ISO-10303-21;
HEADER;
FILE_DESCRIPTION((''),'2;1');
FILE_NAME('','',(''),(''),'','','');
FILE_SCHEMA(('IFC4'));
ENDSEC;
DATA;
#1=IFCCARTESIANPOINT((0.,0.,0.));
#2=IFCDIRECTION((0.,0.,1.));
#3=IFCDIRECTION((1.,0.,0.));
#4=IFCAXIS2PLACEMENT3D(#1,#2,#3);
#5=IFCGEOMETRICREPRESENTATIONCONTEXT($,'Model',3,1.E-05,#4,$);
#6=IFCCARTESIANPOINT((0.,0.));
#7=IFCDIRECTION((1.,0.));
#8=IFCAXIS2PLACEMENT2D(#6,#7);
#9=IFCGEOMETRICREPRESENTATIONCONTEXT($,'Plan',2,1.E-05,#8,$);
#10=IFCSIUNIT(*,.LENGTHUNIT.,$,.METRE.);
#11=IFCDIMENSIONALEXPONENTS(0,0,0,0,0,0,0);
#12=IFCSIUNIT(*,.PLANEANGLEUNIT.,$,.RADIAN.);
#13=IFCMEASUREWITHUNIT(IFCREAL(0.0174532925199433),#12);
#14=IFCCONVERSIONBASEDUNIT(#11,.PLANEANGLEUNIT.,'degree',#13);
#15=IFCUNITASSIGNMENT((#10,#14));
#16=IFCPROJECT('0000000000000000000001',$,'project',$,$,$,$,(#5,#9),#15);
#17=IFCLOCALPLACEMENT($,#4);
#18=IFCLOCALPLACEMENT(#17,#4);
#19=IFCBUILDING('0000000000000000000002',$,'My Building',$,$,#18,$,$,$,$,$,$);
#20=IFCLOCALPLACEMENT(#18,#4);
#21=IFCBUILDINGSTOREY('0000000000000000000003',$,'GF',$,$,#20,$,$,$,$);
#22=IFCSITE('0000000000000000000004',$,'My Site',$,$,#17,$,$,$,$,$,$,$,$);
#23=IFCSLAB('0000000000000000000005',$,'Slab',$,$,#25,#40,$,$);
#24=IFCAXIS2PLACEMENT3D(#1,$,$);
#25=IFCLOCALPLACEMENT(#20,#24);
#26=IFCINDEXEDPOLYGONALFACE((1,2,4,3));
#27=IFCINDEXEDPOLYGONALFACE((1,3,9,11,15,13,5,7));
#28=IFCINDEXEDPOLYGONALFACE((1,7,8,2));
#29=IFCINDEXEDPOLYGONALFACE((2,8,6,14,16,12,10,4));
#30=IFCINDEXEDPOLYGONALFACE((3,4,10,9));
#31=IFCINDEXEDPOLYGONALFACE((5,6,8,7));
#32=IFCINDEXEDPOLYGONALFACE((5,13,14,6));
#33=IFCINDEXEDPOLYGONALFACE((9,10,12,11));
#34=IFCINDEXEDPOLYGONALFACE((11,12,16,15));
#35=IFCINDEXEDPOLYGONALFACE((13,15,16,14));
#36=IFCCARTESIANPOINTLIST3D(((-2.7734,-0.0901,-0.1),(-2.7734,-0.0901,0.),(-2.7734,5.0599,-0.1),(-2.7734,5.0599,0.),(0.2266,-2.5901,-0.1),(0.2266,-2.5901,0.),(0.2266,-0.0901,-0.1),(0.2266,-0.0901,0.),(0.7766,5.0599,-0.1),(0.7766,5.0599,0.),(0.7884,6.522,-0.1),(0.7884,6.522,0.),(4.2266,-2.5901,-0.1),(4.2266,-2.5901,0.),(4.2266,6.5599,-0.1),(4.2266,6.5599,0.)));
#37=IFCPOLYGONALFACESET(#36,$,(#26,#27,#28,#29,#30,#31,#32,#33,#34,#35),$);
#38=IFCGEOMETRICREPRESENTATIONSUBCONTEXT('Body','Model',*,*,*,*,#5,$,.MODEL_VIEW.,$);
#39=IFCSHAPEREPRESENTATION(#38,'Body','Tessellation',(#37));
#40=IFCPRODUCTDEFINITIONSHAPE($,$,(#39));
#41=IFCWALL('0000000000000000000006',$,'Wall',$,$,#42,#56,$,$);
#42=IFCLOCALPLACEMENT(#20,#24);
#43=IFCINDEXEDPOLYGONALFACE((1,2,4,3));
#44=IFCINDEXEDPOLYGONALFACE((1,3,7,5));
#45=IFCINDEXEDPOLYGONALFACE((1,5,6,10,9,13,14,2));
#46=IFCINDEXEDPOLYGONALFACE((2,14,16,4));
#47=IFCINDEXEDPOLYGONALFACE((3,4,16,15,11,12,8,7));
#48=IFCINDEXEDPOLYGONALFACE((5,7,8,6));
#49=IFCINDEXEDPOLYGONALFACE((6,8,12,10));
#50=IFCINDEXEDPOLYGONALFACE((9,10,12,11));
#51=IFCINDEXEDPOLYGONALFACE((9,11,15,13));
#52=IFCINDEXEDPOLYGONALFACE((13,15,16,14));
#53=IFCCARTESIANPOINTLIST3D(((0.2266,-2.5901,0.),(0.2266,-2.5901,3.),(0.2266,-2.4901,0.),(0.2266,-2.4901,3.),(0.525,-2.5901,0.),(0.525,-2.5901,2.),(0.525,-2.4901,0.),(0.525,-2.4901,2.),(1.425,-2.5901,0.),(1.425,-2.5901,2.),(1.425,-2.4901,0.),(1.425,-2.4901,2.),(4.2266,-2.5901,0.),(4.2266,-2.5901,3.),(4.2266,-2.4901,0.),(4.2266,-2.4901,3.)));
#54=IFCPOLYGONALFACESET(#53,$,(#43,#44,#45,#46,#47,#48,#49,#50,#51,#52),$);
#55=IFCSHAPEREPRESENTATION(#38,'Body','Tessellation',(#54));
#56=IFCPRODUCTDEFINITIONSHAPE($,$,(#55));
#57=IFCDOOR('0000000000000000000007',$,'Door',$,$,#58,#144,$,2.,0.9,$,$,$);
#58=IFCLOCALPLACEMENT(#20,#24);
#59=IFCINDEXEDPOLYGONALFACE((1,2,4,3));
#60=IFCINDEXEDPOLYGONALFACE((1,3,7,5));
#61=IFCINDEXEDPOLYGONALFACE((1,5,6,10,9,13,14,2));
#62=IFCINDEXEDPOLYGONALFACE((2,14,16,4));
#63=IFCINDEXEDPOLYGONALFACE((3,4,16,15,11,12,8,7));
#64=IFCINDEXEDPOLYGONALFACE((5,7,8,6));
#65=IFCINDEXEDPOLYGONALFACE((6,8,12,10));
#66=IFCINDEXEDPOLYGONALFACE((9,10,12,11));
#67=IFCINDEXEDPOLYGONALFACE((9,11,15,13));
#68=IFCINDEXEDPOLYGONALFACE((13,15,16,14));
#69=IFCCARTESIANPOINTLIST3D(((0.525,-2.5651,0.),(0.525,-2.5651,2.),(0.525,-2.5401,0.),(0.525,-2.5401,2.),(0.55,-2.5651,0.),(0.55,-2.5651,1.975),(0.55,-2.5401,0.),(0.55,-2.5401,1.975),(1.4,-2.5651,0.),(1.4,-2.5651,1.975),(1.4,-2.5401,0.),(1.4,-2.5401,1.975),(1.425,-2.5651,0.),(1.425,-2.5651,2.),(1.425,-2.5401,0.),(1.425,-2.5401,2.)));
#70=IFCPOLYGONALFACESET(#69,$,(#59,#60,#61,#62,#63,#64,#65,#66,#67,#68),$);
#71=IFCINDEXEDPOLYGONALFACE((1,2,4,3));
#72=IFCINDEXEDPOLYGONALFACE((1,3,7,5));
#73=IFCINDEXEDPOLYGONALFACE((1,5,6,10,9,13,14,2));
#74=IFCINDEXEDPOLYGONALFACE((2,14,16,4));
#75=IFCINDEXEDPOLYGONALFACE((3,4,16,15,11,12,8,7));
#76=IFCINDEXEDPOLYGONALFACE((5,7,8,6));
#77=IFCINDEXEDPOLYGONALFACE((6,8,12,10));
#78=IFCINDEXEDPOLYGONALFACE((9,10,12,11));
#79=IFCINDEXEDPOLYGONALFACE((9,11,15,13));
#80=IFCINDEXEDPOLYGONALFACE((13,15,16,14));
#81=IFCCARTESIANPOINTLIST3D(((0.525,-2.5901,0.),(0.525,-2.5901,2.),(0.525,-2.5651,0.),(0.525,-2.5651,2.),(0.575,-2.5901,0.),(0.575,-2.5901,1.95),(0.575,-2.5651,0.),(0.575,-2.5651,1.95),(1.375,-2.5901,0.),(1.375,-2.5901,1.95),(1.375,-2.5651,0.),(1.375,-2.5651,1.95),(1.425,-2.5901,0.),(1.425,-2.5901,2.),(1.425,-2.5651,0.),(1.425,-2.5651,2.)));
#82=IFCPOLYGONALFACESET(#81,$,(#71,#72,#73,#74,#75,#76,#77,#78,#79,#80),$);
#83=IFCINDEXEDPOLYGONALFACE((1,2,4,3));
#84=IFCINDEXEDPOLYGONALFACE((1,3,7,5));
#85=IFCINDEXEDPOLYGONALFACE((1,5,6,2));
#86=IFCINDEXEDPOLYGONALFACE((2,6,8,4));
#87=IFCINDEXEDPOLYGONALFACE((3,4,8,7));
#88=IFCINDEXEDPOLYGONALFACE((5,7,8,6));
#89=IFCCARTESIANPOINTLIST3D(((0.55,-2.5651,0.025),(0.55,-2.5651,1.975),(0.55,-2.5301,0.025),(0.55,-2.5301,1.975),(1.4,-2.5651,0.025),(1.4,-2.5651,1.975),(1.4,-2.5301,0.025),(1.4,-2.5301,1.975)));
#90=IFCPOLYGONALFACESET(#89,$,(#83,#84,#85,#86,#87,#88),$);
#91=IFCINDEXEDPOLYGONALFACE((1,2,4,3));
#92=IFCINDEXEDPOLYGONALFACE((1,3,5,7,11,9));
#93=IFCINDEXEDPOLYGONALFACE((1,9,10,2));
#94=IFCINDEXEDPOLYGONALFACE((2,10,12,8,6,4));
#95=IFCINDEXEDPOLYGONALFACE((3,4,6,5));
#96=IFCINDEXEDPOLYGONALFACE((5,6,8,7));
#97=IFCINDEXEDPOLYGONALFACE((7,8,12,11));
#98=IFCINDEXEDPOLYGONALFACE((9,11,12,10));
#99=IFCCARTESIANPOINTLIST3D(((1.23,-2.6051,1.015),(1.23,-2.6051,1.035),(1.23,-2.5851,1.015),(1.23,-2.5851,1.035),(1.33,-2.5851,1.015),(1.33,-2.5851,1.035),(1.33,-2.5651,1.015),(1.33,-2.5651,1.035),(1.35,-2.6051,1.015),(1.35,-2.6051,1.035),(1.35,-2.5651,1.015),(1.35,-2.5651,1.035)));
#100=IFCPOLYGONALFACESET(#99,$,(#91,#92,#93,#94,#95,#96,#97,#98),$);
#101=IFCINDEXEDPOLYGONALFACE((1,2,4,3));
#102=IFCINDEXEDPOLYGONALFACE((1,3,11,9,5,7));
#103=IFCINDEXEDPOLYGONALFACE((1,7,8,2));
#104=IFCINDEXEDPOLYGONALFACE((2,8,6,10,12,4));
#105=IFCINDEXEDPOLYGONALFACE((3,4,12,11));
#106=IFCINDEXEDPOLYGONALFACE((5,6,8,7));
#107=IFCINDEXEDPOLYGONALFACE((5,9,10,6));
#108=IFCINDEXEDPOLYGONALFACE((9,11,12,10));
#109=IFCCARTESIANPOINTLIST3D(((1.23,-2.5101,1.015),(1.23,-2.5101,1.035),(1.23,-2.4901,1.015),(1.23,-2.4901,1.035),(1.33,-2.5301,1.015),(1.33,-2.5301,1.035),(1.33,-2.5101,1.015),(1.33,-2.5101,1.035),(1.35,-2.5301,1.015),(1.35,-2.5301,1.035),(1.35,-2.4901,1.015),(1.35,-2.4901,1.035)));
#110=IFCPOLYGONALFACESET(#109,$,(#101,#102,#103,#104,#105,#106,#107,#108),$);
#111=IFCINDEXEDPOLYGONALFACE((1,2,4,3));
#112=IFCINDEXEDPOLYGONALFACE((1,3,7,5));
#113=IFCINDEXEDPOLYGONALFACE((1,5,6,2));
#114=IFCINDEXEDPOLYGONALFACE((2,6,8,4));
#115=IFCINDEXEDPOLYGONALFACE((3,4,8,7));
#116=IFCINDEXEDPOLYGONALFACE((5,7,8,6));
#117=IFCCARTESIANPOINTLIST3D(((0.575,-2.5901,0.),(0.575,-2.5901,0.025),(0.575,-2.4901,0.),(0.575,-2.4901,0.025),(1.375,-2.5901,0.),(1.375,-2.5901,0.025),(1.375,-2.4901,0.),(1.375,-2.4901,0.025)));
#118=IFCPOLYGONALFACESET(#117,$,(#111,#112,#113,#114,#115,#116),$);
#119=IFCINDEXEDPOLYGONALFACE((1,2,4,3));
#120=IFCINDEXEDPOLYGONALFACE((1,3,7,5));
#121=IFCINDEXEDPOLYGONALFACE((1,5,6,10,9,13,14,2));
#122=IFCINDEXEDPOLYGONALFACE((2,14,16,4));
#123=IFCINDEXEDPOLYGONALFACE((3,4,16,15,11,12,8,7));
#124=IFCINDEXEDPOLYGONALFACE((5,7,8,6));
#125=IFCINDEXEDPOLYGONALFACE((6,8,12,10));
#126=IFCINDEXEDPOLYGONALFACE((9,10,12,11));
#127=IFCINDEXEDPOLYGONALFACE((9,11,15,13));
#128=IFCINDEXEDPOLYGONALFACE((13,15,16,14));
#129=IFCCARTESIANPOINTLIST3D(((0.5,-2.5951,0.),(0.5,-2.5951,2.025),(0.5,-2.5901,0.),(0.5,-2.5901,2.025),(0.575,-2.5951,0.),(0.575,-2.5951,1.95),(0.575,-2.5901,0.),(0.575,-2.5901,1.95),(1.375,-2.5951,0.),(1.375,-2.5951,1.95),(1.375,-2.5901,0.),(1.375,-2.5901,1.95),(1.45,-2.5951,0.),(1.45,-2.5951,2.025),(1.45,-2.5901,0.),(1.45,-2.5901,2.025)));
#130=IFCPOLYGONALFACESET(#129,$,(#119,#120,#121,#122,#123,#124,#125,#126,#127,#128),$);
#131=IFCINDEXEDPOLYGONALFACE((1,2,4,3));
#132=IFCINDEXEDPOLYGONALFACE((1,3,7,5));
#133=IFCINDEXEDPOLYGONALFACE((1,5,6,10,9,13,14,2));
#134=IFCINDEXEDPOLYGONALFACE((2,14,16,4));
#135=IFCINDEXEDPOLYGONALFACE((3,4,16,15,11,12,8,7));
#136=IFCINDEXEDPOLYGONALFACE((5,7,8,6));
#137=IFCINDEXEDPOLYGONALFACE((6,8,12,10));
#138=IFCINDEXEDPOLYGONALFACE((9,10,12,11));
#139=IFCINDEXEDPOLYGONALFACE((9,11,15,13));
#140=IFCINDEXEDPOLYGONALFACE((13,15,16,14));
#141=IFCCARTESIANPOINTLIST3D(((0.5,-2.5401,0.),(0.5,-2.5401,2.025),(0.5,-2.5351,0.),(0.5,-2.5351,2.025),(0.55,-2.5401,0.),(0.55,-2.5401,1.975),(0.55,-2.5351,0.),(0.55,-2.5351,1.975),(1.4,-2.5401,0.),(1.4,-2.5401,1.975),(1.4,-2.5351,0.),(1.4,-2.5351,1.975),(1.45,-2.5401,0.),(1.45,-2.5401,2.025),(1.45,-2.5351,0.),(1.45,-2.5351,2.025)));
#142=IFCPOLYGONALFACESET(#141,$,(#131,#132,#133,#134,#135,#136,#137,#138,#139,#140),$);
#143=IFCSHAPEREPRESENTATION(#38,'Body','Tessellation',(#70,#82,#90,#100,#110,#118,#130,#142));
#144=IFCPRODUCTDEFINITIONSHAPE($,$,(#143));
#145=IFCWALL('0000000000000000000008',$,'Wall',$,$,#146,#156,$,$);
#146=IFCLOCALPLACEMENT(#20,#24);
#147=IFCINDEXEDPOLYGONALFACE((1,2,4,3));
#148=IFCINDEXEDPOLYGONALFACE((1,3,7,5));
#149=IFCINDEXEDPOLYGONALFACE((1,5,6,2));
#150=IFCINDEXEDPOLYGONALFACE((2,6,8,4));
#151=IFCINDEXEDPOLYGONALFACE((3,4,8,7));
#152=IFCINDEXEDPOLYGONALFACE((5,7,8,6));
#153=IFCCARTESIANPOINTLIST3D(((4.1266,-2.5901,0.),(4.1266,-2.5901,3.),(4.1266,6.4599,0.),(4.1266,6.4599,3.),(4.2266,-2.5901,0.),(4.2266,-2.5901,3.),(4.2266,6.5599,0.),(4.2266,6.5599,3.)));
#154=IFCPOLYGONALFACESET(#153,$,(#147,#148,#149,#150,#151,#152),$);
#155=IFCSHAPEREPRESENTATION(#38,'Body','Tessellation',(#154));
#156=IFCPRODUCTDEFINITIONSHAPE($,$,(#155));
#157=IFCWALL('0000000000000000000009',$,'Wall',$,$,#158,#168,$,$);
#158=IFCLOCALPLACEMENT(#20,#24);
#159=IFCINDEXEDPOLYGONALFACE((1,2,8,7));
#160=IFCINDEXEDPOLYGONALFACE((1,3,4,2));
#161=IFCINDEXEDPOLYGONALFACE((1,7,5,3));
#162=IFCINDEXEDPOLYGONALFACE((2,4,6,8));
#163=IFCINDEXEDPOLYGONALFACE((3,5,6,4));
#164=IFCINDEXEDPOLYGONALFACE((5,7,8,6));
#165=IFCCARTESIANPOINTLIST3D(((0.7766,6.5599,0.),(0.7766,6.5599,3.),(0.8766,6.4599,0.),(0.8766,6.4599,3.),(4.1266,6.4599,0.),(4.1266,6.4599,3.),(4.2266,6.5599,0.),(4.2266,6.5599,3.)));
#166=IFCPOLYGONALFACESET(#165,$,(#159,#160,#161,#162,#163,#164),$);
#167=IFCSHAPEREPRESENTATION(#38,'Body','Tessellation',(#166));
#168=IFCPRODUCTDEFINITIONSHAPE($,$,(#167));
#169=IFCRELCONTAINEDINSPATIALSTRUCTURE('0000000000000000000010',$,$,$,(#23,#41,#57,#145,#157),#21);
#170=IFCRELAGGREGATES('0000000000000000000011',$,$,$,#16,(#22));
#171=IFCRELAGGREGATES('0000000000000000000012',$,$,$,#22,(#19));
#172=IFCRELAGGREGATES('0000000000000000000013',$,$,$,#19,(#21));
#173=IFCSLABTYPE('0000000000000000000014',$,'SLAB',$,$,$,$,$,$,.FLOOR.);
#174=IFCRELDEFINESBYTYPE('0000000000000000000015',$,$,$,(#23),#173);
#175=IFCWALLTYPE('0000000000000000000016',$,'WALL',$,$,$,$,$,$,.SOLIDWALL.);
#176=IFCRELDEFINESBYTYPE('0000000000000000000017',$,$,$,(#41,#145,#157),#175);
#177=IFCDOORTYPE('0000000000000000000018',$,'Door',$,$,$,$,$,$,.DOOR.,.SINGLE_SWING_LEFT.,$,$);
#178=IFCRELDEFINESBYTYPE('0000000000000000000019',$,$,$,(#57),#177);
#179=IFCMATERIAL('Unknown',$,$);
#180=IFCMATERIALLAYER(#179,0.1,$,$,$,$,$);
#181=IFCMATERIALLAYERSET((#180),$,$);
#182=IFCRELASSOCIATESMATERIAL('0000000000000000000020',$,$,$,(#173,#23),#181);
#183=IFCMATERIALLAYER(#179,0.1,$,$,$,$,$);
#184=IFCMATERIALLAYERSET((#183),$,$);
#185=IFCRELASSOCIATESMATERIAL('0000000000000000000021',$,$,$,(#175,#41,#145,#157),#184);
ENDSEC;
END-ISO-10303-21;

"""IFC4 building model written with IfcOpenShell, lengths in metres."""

from ifc_helpers import new_model, entity, si_unit, converted_unit, frame, origin_with_axes, origin_2d_with_axis, place, context, subcontext, project, spatial, line, indexed_curve, outline, extrude, shape, source, transform, mapped, material, layer, layer_set, layer_usage, type_object, type_shapes, element, fill, save


model = new_model("IFC4")

# Units and contexts
model_context = context("Model", 3, precision=1e-05, world=origin_with_axes())
plan_context = context("Plan", 2, precision=1e-05, world=origin_2d_with_axis())
body_context_1 = subcontext(model_context, "Body", "Model", "MODEL_VIEW")
body_context_2 = subcontext(plan_context, "Body", "Plan", "PLAN_VIEW")
ifc_project = project(units=[si_unit("LENGTHUNIT", "METRE"), converted_unit("PLANEANGLEUNIT", "degree", entity("IfcReal", 0.0174532925199433), si_unit("PLANEANGLEUNIT", "RADIAN"), dimensions=[0, 0, 0, 0, 0, 0, 0])], contexts=[model_context, plan_context])

# Site, building, storey
site_placement = place(None, origin_with_axes())
site = spatial("IfcSite", under=ifc_project, at=site_placement, Name="My Site")
building_placement = place(site_placement, origin_with_axes())
building = spatial("IfcBuilding", under=site, at=building_placement, Name="My Building")
storey_placement = place(building_placement, origin_with_axes())
storey = spatial("IfcBuildingStorey", under=building, at=storey_placement, Name="GF")

# Slab
ifc_material = material(Name="Unknown")
ifc_layer_1 = layer(ifc_material, 0.1)
ifc_layer_set_1 = layer_set([ifc_layer_1])
ifc_layer_usage_1 = layer_usage(ifc_layer_set_1, "AXIS3", "POSITIVE", -0.1)
slab_type = type_object("IfcSlabType", Name="SLAB", PredefinedType="FLOOR", material=ifc_layer_set_1)
slab_placement = place(storey_placement, frame((4.2266, -2.5901, 0.0), z_axis=(0.0, 0.0, 1.0), x_axis=(1.0, 0.0, 0.0)))
element("IfcSlab", 1, at=slab_placement, inside=storey, type_object=slab_type, material=ifc_layer_usage_1, Name="Slab", context=body_context_1, shape_type="SweptSolid", body=[
    extrude(outline(indexed_curve([(0.0, 0.0), (0.0, 9.15), (-3.4382, 9.1121), (-3.45, 7.65), (-7.0, 7.65), (-7.0, 2.5), (-4.0, 2.5), (-4.0, 0.0), (0.0, 0.0)])), frame((0.0, 0.0, -0.1), z_axis=(0.0, 0.0, 1.0), x_axis=(1.0, 0.0, 0.0)), (0.0, 0.0, 1.0), 0.1),
])

# Wall, opening, door
ifc_layer_2 = layer(ifc_material, 0.1)
ifc_layer_set_2 = layer_set([ifc_layer_2])
ifc_layer_usage_2 = layer_usage(ifc_layer_set_2, "AXIS2", "POSITIVE", 0.0)
wall_type = type_object("IfcWallType", Name="WALL", PredefinedType="SOLIDWALL", material=ifc_layer_set_2)
wall_1_placement = place(storey_placement, frame((0.2266, -2.5901, 0.0), z_axis=(0.0, 0.0, 1.0), x_axis=(1.0, 0.0, 0.0)))
wall_1 = element("IfcWall", 2, at=wall_1_placement, inside=storey, type_object=wall_type, material=ifc_layer_usage_2, Name="Wall", context=body_context_1, shape_type="SweptSolid", body=[
    extrude(outline(indexed_curve([(0.0, 0.0), (0.0, 0.1), (4.0, 0.1), (4.0, 0.0)], segments=[line(1, 2, 3, 4, 1)])), origin_with_axes(), (0.0, 0.0, 1.0), 3.0),
])
shared_shape_1 = source(origin_with_axes(), body_context_1, "Body", "SweptSolid", [
    extrude(outline(indexed_curve([(0.0, 0.0), (0.9, 0.0), (0.9, 2.0), (0.0, 2.0)], segments=[line(1, 2, 3, 4, 1)])), frame((0.0, -0.6, 0.0), z_axis=(0.0, -1.0, 0.0), x_axis=(1.0, 0.0, 0.0)), (0.0, 0.0, -1.0), 1.2),
])
opening_1_placement = place(wall_1_placement, frame((0.2984, 0.0, 0.0), z_axis=(0.0, 0.0, 1.0), x_axis=(1.0, 0.0, 0.0)))
opening_1 = element("IfcOpeningElement", 3, at=opening_1_placement, cuts=wall_1, PredefinedType="OPENING", context=body_context_1, shape_type="MappedRepresentation", body=[
    mapped(shared_shape_1, transform((0.0, 0.0, 0.0), x_axis=(1.0, 0.0, 0.0), y_axis=(0.0, 1.0, 0.0), z_axis=(0.0, 0.0, 1.0), scale=1.0)),
])
door_type = type_object("IfcDoorType", Name="Door", OperationType="SINGLE_SWING_LEFT", PredefinedType="DOOR")
shared_shape_2 = source(origin_with_axes(), body_context_1, "Body", "SweptSolid", [
    extrude(outline(indexed_curve([(0.0, 0.0), (0.0, 2.0), (0.9, 2.0), (0.9, 0.0), (0.875, 0.0), (0.875, 1.975), (0.025, 1.975), (0.025, 0.0)], segments=[line(1, 2, 3, 4, 5, 6, 7, 8, 1)])), frame((0.0, 0.025, 0.0), z_axis=(0.0, -1.0, 0.0), x_axis=(1.0, 0.0, 0.0)), (0.0, 0.0, -1.0), 0.025),
    extrude(outline(indexed_curve([(0.0, 0.0), (0.0, 2.0), (0.9, 2.0), (0.9, 0.0), (0.85, 0.0), (0.85, 1.95), (0.05, 1.95), (0.05, 0.0)], segments=[line(1, 2, 3, 4, 5, 6, 7, 8, 1)])), frame((0.0, 0.0, 0.0), z_axis=(0.0, -1.0, 0.0), x_axis=(1.0, 0.0, 0.0)), (0.0, 0.0, -1.0), 0.025),
    extrude(outline(indexed_curve([(0.0, 0.0), (0.85, 0.0), (0.85, 0.035), (0.0, 0.035)], segments=[line(1, 2, 3, 4, 1)])), frame((0.025, 0.025, 0.025), z_axis=(0.0, 0.0, 1.0), x_axis=(1.0, 0.0, 0.0)), (0.0, 0.0, 1.0), 1.95),
    extrude(outline(indexed_curve([(0.0, 0.0), (0.0, -0.04), (-0.12, -0.04), (-0.12, -0.02), (-0.02, -0.02), (-0.02, 0.0)], segments=[line(1, 2, 3, 4, 5, 6, 1)])), frame((0.825, 0.025, 1.015), z_axis=(0.0, 0.0, 1.0), x_axis=(1.0, 0.0, 0.0)), (0.0, 0.0, 1.0), 0.02),
    extrude(outline(indexed_curve([(0.0, 0.0), (0.0, 0.04), (-0.12, 0.04), (-0.12, 0.02), (-0.02, 0.02), (-0.02, 0.0)], segments=[line(1, 2, 3, 4, 5, 6, 1)])), frame((0.825, 0.06, 1.015), z_axis=(0.0, 0.0, 1.0), x_axis=(1.0, 0.0, 0.0)), (0.0, 0.0, 1.0), 0.02),
    extrude(outline(indexed_curve([(0.0, 0.0), (0.8, 0.0), (0.8, 0.1), (0.0, 0.1)], segments=[line(1, 2, 3, 4, 1)])), frame((0.05, 0.0, 0.0), z_axis=(0.0, 0.0, 1.0), x_axis=(1.0, 0.0, 0.0)), (0.0, 0.0, 1.0), 0.025),
    extrude(outline(indexed_curve([(0.0, 0.0), (0.0, 2.025), (0.95, 2.025), (0.95, 0.0), (0.875, 0.0), (0.875, 1.95), (0.075, 1.95), (0.075, 0.0)], segments=[line(1, 2, 3, 4, 5, 6, 7, 8, 1)])), frame((-0.025, -0.005, 0.0), z_axis=(0.0, -1.0, 0.0), x_axis=(1.0, 0.0, 0.0)), (0.0, 0.0, -1.0), 0.005),
    extrude(outline(indexed_curve([(0.0, 0.0), (0.0, 2.025), (0.95, 2.025), (0.95, 0.0), (0.9, 0.0), (0.9, 1.975), (0.05, 1.975), (0.05, 0.0)], segments=[line(1, 2, 3, 4, 5, 6, 7, 8, 1)])), frame((-0.025, 0.05, 0.0), z_axis=(0.0, -1.0, 0.0), x_axis=(1.0, 0.0, 0.0)), (0.0, 0.0, -1.0), 0.005),
])
shared_shape_3 = source(origin_with_axes(), body_context_2, "Body", "Curve2D", [
    entity("IfcIndexedPolyCurve", entity("IfcCartesianPointList2D", [[0.0, 0.0], [0.0, 0.05], [0.025, 0.05], [0.025, 0.025], [0.05, 0.025], [0.05, 0.0]]), [entity("IfcLineIndex", [1, 2, 3, 4, 5, 6, 1])]),
    entity("IfcIndexedPolyCurve", entity("IfcCartesianPointList2D", [[0.9, 0.0], [0.9, 0.05], [0.875, 0.05], [0.875, 0.025], [0.85, 0.025], [0.85, 0.0]]), [entity("IfcLineIndex", [1, 2, 3, 4, 5, 6, 1])]),
    entity("IfcTrimmedCurve", entity("IfcEllipse", entity("IfcAxis2Placement2D", entity("IfcCartesianPoint", [0.06, 0.05]), entity("IfcDirection", [1.0, 0.0])), 0.815, 0.85), [entity("IfcCartesianPoint", [0.875, 0.05])], [entity("IfcCartesianPoint", [0.06, 0.9])], True, "CARTESIAN"),
    entity("IfcIndexedPolyCurve", entity("IfcCartesianPointList2D", [[0.025, 0.05], [0.06, 0.05], [0.06, 0.9], [0.025, 0.9]]), [entity("IfcLineIndex", [1, 2, 3, 4, 1])]),
])
type_shapes(door_type, [shared_shape_2, shared_shape_3])
door_1_placement = place(opening_1_placement, origin_with_axes())
door_1 = element("IfcDoor", 4, at=door_1_placement, inside=storey, type_object=door_type, Name="Door", OverallHeight=2.0, OverallWidth=0.9, shapes=[
    shape(body_context_1, "Body", "MappedRepresentation", [mapped(shared_shape_2, transform((0.0, 0.0, 0.0), x_axis=(1.0, 0.0, 0.0), y_axis=(0.0, 1.0, 0.0), z_axis=(0.0, 0.0, 1.0), scale=1.0))]),
    shape(body_context_2, "Body", "MappedRepresentation", [mapped(shared_shape_3, transform((0.0, 0.0, 0.0), x_axis=(1.0, 0.0, 0.0), y_axis=(0.0, 1.0, 0.0), z_axis=(0.0, 0.0, 1.0), scale=1.0))]),
])
fill(opening_1, door_1)

# Walls
ifc_layer_usage_3 = layer_usage(ifc_layer_set_2, "AXIS2", "POSITIVE", 0.0)
wall_2_placement = place(storey_placement, frame((4.2266, -2.5901, 0.0), z_axis=(0.0, 0.0, 1.0), x_axis=(0.0, 1.0, 0.0)))
element("IfcWall", 5, at=wall_2_placement, inside=storey, type_object=wall_type, material=ifc_layer_usage_3, Name="Wall", context=body_context_1, shape_type="SweptSolid", body=[
    extrude(outline(indexed_curve([(0.0, 0.0), (0.0, 0.1), (9.05, 0.1), (9.15, 0.0)], segments=[line(1, 2, 3, 4, 1)])), origin_with_axes(), (0.0, 0.0, 1.0), 3.0),
])
ifc_layer_usage_4 = layer_usage(ifc_layer_set_2, "AXIS2", "POSITIVE", 0.0)
wall_3_placement = place(storey_placement, frame((4.2266, 6.5599, 0.0), z_axis=(0.0, 0.0, 1.0), x_axis=(-1.0, 0.0, 0.0)))
element("IfcWall", 6, at=wall_3_placement, inside=storey, type_object=wall_type, material=ifc_layer_usage_4, Name="Wall", context=body_context_1, shape_type="SweptSolid", body=[
    extrude(outline(indexed_curve([(0.0, 0.0), (0.1, 0.1), (3.35, 0.1), (3.45, 0.0)], segments=[line(1, 2, 3, 4, 1)])), origin_with_axes(), (0.0, 0.0, 1.0), 3.0),
])

save(model, "model.ifc")
